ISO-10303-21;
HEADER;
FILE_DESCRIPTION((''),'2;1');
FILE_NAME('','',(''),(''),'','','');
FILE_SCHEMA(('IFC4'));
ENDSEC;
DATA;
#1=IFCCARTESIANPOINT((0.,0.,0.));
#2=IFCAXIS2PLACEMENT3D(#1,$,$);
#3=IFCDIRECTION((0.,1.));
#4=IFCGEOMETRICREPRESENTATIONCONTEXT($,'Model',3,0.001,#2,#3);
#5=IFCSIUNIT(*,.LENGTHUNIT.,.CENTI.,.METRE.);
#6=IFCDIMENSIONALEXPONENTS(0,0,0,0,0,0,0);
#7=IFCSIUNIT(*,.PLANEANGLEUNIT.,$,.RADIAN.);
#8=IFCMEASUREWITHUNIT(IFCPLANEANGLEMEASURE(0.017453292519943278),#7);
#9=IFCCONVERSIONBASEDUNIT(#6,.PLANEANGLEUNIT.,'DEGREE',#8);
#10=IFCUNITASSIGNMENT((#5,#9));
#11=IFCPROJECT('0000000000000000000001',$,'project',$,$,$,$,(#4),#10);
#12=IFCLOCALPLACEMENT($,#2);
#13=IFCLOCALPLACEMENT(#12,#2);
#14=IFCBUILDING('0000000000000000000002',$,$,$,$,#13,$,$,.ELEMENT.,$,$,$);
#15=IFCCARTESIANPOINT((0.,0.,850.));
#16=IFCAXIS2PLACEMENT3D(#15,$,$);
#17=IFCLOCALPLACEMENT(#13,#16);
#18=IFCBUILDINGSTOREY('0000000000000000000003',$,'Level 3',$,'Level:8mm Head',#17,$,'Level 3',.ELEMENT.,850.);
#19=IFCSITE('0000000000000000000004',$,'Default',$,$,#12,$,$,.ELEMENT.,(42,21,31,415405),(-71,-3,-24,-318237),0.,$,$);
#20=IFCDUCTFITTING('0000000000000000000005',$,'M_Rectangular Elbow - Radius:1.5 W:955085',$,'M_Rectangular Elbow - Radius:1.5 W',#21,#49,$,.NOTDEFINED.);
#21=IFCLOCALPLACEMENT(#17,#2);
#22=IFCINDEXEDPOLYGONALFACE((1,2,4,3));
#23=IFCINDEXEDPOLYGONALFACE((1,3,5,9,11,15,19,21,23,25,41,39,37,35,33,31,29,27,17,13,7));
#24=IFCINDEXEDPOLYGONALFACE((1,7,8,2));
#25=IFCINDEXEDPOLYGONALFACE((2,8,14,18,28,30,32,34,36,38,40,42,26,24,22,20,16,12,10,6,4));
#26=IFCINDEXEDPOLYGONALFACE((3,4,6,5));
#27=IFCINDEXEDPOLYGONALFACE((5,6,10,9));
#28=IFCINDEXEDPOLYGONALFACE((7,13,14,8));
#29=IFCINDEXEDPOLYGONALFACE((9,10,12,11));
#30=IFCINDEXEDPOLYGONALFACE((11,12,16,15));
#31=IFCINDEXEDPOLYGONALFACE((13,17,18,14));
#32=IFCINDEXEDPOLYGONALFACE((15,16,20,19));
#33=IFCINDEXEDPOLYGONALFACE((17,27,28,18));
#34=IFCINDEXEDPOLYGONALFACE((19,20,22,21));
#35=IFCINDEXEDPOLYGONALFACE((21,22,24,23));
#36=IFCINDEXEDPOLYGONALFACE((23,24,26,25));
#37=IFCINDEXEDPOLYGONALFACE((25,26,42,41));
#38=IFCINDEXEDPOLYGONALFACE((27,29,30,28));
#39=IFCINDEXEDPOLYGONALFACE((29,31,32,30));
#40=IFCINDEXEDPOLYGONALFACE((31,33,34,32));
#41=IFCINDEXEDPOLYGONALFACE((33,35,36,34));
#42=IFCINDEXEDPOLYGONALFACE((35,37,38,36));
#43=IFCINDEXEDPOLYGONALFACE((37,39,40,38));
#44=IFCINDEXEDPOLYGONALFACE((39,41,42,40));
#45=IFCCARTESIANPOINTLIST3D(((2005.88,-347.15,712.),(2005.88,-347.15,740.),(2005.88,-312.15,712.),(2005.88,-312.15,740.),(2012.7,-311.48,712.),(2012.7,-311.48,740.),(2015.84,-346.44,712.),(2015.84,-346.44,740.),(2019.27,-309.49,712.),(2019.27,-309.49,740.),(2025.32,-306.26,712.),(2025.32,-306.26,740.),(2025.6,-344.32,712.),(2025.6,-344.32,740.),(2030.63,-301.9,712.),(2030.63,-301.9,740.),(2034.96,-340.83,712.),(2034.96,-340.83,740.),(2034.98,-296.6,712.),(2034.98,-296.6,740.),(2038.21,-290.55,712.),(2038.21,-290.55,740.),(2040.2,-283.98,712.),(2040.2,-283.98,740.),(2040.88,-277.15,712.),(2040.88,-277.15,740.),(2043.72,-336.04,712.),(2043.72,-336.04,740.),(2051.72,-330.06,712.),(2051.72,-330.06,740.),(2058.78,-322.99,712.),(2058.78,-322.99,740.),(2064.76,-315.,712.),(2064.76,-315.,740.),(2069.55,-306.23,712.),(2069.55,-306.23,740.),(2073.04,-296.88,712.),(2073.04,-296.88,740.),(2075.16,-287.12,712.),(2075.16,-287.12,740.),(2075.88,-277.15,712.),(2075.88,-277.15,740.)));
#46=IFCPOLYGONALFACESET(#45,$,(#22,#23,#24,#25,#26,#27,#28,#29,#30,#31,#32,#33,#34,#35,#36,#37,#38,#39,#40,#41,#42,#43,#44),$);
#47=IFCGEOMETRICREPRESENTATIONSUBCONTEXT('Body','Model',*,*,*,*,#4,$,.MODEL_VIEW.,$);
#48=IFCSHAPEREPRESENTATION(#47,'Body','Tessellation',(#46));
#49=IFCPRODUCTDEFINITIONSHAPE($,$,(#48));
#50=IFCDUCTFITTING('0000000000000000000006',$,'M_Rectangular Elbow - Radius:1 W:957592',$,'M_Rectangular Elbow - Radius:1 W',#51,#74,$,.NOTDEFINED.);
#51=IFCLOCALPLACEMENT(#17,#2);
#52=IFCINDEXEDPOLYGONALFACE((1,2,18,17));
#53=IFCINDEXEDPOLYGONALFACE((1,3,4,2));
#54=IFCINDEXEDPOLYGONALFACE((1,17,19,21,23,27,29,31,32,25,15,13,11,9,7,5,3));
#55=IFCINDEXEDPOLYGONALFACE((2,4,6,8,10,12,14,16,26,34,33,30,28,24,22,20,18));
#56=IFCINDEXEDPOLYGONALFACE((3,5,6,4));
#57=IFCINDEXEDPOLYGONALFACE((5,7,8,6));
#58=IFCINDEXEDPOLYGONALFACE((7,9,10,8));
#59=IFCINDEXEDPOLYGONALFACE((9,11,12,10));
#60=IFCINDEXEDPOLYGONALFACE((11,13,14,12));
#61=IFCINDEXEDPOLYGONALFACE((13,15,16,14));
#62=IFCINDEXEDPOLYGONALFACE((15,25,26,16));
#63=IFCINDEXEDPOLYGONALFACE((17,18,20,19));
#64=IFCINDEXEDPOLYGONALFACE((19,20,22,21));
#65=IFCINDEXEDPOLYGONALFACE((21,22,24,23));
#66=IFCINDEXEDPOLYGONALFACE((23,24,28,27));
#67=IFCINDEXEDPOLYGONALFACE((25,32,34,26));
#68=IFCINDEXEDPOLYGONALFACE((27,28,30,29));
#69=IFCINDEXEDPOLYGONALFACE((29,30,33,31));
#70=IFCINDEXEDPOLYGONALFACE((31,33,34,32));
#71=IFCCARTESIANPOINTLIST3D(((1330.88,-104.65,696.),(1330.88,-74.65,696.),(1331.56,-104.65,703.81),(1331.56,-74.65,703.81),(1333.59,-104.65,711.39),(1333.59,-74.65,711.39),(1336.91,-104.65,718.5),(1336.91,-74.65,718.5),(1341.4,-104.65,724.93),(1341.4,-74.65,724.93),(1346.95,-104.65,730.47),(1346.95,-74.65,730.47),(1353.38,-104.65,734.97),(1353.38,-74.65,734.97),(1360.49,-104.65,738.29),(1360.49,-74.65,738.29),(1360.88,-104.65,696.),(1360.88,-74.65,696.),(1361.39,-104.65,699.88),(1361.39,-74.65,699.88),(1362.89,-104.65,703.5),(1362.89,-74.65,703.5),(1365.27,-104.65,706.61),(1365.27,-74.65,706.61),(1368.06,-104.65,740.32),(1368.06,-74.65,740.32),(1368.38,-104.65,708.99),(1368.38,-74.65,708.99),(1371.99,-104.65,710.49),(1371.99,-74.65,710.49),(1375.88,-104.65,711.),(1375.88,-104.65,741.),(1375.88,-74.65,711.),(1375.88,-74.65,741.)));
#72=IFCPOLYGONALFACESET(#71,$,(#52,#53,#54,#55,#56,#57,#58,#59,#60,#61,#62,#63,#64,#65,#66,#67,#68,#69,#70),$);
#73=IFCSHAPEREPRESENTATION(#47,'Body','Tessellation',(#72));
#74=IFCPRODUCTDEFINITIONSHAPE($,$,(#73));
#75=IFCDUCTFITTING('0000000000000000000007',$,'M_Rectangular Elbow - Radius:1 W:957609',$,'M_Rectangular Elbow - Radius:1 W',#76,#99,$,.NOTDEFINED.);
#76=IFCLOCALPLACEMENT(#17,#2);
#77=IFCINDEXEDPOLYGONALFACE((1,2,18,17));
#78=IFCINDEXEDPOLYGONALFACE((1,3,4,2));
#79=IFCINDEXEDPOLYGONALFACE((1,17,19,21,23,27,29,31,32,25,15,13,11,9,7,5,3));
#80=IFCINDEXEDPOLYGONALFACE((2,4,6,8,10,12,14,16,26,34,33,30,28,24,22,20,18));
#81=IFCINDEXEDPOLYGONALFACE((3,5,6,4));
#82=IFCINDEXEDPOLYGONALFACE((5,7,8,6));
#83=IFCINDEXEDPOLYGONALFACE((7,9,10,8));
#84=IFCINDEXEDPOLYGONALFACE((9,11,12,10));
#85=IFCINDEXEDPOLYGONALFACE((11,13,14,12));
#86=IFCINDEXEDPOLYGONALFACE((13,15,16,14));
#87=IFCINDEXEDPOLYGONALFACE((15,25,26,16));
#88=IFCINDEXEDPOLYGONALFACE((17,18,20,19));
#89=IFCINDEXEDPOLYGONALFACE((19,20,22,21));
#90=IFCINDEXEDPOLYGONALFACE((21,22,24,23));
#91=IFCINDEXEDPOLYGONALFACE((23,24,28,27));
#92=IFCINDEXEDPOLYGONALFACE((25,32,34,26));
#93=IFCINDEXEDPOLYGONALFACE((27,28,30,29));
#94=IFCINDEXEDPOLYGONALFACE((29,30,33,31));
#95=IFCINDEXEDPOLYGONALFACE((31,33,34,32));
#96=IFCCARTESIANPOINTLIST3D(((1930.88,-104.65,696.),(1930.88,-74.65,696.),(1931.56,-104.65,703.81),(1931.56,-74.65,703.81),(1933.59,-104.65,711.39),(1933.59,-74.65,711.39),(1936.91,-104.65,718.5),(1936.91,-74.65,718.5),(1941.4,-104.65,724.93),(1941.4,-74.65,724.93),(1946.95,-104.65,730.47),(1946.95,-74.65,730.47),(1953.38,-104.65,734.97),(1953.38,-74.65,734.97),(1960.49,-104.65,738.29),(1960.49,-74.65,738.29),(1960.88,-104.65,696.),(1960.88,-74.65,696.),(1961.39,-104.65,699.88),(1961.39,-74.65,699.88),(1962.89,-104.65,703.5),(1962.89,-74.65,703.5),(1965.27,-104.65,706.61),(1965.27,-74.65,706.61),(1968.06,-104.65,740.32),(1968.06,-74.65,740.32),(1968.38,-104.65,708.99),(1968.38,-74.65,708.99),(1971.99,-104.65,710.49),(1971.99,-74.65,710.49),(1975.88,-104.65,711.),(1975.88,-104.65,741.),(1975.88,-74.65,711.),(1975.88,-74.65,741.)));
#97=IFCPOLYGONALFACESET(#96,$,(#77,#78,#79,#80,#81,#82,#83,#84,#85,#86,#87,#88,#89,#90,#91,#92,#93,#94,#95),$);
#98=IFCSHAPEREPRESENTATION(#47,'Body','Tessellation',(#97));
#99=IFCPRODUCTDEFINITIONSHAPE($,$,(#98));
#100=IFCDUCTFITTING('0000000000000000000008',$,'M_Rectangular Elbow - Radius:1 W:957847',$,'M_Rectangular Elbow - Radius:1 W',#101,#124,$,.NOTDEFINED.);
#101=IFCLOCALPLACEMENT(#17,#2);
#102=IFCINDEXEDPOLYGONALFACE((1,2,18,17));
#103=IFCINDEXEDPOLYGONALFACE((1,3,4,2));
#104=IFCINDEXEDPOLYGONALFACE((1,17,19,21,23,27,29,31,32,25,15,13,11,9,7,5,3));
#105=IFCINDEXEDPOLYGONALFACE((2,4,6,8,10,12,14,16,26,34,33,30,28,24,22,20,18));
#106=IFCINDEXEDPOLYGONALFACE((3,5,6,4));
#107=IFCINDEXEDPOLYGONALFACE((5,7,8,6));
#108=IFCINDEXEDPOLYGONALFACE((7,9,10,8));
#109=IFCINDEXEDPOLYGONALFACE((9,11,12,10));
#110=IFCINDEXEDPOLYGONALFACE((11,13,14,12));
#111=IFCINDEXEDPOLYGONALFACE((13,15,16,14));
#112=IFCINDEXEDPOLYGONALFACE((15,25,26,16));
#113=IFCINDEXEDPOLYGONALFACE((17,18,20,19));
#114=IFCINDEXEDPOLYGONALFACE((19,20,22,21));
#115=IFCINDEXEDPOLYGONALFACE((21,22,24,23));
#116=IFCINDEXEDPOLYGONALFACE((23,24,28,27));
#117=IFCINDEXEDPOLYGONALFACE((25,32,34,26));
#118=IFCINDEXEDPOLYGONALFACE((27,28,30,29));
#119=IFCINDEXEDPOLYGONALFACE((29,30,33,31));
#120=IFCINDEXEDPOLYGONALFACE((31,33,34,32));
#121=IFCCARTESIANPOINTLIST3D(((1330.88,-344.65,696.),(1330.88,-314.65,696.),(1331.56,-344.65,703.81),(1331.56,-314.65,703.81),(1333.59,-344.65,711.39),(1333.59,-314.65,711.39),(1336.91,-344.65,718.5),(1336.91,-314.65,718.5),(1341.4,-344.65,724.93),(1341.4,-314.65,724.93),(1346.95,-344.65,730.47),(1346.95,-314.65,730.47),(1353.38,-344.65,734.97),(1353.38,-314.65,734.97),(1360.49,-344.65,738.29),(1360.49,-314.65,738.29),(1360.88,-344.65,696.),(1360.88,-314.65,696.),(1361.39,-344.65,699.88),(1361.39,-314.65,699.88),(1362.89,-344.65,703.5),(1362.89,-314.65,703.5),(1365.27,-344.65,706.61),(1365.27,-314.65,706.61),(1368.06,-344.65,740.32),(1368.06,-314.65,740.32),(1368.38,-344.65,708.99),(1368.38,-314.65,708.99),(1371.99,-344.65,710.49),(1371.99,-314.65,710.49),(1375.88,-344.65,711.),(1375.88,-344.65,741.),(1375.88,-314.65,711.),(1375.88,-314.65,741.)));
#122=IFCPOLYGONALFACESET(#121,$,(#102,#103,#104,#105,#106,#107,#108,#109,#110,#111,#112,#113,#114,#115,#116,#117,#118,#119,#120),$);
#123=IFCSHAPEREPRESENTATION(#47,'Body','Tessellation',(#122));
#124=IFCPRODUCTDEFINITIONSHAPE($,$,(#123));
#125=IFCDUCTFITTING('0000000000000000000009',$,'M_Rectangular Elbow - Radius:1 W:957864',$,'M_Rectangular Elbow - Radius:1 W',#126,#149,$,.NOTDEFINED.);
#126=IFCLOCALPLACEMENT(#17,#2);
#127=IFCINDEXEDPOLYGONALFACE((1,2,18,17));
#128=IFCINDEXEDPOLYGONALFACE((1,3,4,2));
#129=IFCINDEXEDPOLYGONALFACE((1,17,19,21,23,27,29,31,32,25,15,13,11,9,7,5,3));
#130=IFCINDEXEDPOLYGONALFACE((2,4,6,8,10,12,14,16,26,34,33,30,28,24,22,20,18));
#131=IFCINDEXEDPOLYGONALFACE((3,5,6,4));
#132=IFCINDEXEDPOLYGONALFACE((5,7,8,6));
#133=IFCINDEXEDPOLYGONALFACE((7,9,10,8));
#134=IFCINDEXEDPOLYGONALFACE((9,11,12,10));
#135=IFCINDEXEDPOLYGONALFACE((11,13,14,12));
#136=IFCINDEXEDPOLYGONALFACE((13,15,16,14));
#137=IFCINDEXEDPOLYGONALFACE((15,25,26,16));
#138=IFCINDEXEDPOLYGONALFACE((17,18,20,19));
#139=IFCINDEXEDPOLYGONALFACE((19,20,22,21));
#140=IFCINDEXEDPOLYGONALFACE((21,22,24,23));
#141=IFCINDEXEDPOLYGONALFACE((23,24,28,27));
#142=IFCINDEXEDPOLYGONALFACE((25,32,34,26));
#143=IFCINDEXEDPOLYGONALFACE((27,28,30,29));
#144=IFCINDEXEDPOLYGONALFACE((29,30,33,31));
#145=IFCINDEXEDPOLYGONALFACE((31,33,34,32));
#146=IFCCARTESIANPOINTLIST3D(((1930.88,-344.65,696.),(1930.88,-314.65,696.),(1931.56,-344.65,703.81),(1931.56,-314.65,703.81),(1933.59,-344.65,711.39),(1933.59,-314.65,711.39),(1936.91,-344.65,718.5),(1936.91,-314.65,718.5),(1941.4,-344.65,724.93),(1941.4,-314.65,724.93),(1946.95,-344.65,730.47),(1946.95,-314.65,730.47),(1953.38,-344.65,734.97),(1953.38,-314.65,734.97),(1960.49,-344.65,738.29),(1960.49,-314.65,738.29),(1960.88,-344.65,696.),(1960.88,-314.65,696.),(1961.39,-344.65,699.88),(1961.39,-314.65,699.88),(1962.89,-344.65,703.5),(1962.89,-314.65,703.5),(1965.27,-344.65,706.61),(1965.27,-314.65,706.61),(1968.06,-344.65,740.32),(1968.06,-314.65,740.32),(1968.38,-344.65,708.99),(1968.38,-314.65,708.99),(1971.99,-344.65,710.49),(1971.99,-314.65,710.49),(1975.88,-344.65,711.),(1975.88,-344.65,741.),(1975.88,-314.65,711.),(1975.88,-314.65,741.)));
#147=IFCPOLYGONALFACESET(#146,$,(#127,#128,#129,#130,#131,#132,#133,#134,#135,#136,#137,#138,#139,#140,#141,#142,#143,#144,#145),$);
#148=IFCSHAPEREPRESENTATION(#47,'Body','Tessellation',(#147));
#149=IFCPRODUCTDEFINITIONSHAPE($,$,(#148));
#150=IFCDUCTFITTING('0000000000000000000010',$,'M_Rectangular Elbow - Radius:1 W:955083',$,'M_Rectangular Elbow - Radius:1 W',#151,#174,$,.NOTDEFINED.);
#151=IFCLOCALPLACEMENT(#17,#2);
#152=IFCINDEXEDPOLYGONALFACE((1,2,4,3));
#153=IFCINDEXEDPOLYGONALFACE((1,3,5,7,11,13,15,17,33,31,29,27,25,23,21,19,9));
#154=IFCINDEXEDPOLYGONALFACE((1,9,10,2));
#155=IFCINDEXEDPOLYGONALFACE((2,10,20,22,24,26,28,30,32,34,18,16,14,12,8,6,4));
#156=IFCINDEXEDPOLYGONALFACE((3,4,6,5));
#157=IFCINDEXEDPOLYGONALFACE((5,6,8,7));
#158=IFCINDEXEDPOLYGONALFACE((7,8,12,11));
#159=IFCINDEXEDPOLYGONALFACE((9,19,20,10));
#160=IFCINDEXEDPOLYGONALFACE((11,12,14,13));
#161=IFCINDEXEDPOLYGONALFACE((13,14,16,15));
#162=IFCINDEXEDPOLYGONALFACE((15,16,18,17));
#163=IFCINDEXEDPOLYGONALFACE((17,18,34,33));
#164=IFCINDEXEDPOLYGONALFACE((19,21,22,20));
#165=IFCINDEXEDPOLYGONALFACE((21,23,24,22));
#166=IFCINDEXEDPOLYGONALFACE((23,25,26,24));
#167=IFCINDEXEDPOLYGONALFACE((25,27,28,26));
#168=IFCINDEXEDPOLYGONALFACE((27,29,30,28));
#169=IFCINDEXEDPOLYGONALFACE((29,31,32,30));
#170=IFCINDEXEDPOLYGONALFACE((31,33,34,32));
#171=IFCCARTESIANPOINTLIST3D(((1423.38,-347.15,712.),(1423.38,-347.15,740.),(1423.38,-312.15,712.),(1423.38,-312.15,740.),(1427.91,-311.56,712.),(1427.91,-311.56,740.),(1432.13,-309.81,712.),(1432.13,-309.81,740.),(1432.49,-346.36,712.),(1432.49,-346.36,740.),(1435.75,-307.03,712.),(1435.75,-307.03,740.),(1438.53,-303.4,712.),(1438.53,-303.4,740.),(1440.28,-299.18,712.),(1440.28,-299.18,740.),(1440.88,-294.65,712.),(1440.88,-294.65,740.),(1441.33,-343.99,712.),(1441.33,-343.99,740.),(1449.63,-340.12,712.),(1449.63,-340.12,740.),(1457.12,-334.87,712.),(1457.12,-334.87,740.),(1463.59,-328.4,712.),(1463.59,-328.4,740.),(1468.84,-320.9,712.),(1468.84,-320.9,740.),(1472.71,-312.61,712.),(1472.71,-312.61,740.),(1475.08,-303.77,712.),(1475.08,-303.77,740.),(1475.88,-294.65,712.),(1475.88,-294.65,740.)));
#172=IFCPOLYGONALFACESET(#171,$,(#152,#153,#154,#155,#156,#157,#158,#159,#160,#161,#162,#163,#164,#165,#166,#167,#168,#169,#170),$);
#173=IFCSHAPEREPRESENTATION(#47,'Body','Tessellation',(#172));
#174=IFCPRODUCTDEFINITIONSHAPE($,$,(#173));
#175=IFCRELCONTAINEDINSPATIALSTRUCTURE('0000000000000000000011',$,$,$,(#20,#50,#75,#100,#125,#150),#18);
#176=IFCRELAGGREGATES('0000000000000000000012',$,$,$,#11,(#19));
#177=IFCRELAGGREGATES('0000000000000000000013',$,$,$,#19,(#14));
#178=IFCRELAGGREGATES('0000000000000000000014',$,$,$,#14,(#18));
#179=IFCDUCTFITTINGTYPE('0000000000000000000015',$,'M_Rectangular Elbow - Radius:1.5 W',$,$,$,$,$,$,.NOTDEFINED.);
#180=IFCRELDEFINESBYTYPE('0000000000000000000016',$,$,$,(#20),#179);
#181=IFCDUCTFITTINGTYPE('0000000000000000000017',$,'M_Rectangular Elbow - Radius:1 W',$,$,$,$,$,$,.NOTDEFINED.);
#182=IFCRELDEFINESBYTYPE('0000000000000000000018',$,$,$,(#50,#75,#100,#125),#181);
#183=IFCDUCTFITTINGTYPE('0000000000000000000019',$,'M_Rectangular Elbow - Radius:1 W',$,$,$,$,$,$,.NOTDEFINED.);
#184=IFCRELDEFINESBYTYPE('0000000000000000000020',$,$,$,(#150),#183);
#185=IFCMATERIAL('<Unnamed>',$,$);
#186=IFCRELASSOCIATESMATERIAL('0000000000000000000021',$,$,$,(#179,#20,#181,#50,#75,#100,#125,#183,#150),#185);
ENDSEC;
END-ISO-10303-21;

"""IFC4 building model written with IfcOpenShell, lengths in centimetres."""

from ifc_helpers import new_model, entity, si_unit, converted_unit, direction, frame, origin, place, context, subcontext, project, spatial, line, arc, indexed_curve, outline, extrude, source, transform, mapped, material, type_object, type_shapes, element, save


model = new_model("IFC4")

# Units and contexts
model_context = context("Model", 3, precision=0.001, world=origin(), true_north=direction((0.0, 1.0)))
body_context = subcontext(model_context, "Body", "Model", "MODEL_VIEW")
ifc_project = project(units=[si_unit("LENGTHUNIT", "METRE", prefix="CENTI"), converted_unit("PLANEANGLEUNIT", "DEGREE", entity("IfcPlaneAngleMeasure", 0.017453292519943278), si_unit("PLANEANGLEUNIT", "RADIAN"), dimensions=[0, 0, 0, 0, 0, 0, 0])], contexts=[model_context])

# Site, building, storey
site_placement = place(None, origin())
site = spatial("IfcSite", under=ifc_project, at=site_placement, Name="Default", CompositionType="ELEMENT", RefLatitude=(42, 21, 31, 415405), RefLongitude=(-71, -3, -24, -318237), RefElevation=0.0)
building_placement = place(site_placement, origin())
building = spatial("IfcBuilding", under=site, at=building_placement, CompositionType="ELEMENT")
storey_placement = place(building_placement, frame((0.0, 0.0, 850.0)))
storey = spatial("IfcBuildingStorey", under=building, at=storey_placement, Name="Level 3", ObjectType="Level:8mm Head", LongName="Level 3", CompositionType="ELEMENT", Elevation=850.0)

# Duct fittings
ifc_material = material(Name="<Unnamed>")
duct_fitting_type_1 = type_object("IfcDuctFittingType", Name="M_Rectangular Elbow - Radius:1.5 W", PredefinedType="NOTDEFINED", material=ifc_material)
shared_shape_1 = source(origin(), body_context, "Body", "SweptSolid", [
    extrude(outline(indexed_curve([(-43.75, -26.25), (-8.75, -26.25), (1.5, -1.5), (26.25, 8.75), (26.25, 43.75), (-23.25, 23.25)], segments=[line(1, 2), arc(2, 3, 4), line(4, 5), arc(5, 6, 1)], self_intersect=False)), frame((-26.25, 26.25, -14.0), z_axis=(0.0, 0.0, 1.0), x_axis=(-1.0, 0.0, 0.0)), (0.0, 0.0, 1.0), 28.0),
])
type_shapes(duct_fitting_type_1, [shared_shape_1])
duct_fitting_1_placement = place(storey_placement, frame((2058.38, -329.65, 726.0)))
element("IfcDuctFitting", 1, at=duct_fitting_1_placement, inside=storey, type_object=duct_fitting_type_1, material=ifc_material, Name="M_Rectangular Elbow - Radius:1.5 W:955085", ObjectType="M_Rectangular Elbow - Radius:1.5 W", PredefinedType="NOTDEFINED", context=body_context, shape_type="MappedRepresentation", body=[
    mapped(shared_shape_1, transform((0.0, 0.0, 0.0), scale=1.0)),
])
duct_fitting_type_2 = type_object("IfcDuctFittingType", Name="M_Rectangular Elbow - Radius:1 W", PredefinedType="NOTDEFINED", material=ifc_material)
shared_shape_2 = source(origin(), body_context, "Body", "SweptSolid", [
    extrude(outline(indexed_curve([(-30.0, -15.0), (0.0, -15.0), (4.39, -4.39), (15.0, 0.0), (15.0, 30.0), (-16.82, 16.82)], segments=[line(1, 2), arc(2, 3, 4), line(4, 5), arc(5, 6, 1)], self_intersect=False)), frame((-15.0, 15.0, -15.0), z_axis=(0.0, 0.0, 1.0), x_axis=(-1.0, 0.0, 0.0)), (0.0, 0.0, 1.0), 30.0),
])
type_shapes(duct_fitting_type_2, [shared_shape_2])
for number, where, z_axis, x_axis, name in (
    (2, (1345.88, -89.65, 726.0), (0.0, -1.0, 0.0), (-1.0, 0.0, 0.0), "M_Rectangular Elbow - Radius:1 W:957592"),
    (3, (1945.88, -89.65, 726.0), (0.0, -1.0, 0.0), (-1.0, 0.0, 0.0), "M_Rectangular Elbow - Radius:1 W:957609"),
    (4, (1345.88, -329.65, 726.0), (0.0, -1.0, 0.0), (-1.0, 0.0, 0.0), "M_Rectangular Elbow - Radius:1 W:957847"),
    (5, (1945.88, -329.65, 726.0), (0.0, -1.0, 0.0), (-1.0, 0.0, 0.0), "M_Rectangular Elbow - Radius:1 W:957864"),
):
    element("IfcDuctFitting", number, at=place(storey_placement, frame(where, z_axis=z_axis, x_axis=x_axis)), inside=storey, type_object=duct_fitting_type_2, material=ifc_material, Name=name, ObjectType="M_Rectangular Elbow - Radius:1 W", PredefinedType="NOTDEFINED", context=body_context, shape_type="MappedRepresentation", body=[
        mapped(shared_shape_2, transform((0.0, 0.0, 0.0), scale=1.0)),
    ])
duct_fitting_type_3 = type_object("IfcDuctFittingType", Name="M_Rectangular Elbow - Radius:1 W", PredefinedType="NOTDEFINED", material=ifc_material)
shared_shape_3 = source(origin(), body_context, "Body", "SweptSolid", [
    extrude(outline(indexed_curve([(-35.0, -17.5), (0.0, -17.5), (5.13, -5.13), (17.5, 0.0), (17.5, 35.0), (-19.62, 19.62)], segments=[line(1, 2), arc(2, 3, 4), line(4, 5), arc(5, 6, 1)], self_intersect=False)), frame((-17.5, 17.5, -14.0), z_axis=(0.0, 0.0, 1.0), x_axis=(-1.0, 0.0, 0.0)), (0.0, 0.0, 1.0), 28.0),
])
type_shapes(duct_fitting_type_3, [shared_shape_3])
duct_fitting_2_placement = place(storey_placement, frame((1458.38, -329.65, 726.0)))
element("IfcDuctFitting", 6, at=duct_fitting_2_placement, inside=storey, type_object=duct_fitting_type_3, material=ifc_material, Name="M_Rectangular Elbow - Radius:1 W:955083", ObjectType="M_Rectangular Elbow - Radius:1 W", PredefinedType="NOTDEFINED", context=body_context, shape_type="MappedRepresentation", body=[
    mapped(shared_shape_3, transform((0.0, 0.0, 0.0), scale=1.0)),
])

save(model, "model.ifc")
